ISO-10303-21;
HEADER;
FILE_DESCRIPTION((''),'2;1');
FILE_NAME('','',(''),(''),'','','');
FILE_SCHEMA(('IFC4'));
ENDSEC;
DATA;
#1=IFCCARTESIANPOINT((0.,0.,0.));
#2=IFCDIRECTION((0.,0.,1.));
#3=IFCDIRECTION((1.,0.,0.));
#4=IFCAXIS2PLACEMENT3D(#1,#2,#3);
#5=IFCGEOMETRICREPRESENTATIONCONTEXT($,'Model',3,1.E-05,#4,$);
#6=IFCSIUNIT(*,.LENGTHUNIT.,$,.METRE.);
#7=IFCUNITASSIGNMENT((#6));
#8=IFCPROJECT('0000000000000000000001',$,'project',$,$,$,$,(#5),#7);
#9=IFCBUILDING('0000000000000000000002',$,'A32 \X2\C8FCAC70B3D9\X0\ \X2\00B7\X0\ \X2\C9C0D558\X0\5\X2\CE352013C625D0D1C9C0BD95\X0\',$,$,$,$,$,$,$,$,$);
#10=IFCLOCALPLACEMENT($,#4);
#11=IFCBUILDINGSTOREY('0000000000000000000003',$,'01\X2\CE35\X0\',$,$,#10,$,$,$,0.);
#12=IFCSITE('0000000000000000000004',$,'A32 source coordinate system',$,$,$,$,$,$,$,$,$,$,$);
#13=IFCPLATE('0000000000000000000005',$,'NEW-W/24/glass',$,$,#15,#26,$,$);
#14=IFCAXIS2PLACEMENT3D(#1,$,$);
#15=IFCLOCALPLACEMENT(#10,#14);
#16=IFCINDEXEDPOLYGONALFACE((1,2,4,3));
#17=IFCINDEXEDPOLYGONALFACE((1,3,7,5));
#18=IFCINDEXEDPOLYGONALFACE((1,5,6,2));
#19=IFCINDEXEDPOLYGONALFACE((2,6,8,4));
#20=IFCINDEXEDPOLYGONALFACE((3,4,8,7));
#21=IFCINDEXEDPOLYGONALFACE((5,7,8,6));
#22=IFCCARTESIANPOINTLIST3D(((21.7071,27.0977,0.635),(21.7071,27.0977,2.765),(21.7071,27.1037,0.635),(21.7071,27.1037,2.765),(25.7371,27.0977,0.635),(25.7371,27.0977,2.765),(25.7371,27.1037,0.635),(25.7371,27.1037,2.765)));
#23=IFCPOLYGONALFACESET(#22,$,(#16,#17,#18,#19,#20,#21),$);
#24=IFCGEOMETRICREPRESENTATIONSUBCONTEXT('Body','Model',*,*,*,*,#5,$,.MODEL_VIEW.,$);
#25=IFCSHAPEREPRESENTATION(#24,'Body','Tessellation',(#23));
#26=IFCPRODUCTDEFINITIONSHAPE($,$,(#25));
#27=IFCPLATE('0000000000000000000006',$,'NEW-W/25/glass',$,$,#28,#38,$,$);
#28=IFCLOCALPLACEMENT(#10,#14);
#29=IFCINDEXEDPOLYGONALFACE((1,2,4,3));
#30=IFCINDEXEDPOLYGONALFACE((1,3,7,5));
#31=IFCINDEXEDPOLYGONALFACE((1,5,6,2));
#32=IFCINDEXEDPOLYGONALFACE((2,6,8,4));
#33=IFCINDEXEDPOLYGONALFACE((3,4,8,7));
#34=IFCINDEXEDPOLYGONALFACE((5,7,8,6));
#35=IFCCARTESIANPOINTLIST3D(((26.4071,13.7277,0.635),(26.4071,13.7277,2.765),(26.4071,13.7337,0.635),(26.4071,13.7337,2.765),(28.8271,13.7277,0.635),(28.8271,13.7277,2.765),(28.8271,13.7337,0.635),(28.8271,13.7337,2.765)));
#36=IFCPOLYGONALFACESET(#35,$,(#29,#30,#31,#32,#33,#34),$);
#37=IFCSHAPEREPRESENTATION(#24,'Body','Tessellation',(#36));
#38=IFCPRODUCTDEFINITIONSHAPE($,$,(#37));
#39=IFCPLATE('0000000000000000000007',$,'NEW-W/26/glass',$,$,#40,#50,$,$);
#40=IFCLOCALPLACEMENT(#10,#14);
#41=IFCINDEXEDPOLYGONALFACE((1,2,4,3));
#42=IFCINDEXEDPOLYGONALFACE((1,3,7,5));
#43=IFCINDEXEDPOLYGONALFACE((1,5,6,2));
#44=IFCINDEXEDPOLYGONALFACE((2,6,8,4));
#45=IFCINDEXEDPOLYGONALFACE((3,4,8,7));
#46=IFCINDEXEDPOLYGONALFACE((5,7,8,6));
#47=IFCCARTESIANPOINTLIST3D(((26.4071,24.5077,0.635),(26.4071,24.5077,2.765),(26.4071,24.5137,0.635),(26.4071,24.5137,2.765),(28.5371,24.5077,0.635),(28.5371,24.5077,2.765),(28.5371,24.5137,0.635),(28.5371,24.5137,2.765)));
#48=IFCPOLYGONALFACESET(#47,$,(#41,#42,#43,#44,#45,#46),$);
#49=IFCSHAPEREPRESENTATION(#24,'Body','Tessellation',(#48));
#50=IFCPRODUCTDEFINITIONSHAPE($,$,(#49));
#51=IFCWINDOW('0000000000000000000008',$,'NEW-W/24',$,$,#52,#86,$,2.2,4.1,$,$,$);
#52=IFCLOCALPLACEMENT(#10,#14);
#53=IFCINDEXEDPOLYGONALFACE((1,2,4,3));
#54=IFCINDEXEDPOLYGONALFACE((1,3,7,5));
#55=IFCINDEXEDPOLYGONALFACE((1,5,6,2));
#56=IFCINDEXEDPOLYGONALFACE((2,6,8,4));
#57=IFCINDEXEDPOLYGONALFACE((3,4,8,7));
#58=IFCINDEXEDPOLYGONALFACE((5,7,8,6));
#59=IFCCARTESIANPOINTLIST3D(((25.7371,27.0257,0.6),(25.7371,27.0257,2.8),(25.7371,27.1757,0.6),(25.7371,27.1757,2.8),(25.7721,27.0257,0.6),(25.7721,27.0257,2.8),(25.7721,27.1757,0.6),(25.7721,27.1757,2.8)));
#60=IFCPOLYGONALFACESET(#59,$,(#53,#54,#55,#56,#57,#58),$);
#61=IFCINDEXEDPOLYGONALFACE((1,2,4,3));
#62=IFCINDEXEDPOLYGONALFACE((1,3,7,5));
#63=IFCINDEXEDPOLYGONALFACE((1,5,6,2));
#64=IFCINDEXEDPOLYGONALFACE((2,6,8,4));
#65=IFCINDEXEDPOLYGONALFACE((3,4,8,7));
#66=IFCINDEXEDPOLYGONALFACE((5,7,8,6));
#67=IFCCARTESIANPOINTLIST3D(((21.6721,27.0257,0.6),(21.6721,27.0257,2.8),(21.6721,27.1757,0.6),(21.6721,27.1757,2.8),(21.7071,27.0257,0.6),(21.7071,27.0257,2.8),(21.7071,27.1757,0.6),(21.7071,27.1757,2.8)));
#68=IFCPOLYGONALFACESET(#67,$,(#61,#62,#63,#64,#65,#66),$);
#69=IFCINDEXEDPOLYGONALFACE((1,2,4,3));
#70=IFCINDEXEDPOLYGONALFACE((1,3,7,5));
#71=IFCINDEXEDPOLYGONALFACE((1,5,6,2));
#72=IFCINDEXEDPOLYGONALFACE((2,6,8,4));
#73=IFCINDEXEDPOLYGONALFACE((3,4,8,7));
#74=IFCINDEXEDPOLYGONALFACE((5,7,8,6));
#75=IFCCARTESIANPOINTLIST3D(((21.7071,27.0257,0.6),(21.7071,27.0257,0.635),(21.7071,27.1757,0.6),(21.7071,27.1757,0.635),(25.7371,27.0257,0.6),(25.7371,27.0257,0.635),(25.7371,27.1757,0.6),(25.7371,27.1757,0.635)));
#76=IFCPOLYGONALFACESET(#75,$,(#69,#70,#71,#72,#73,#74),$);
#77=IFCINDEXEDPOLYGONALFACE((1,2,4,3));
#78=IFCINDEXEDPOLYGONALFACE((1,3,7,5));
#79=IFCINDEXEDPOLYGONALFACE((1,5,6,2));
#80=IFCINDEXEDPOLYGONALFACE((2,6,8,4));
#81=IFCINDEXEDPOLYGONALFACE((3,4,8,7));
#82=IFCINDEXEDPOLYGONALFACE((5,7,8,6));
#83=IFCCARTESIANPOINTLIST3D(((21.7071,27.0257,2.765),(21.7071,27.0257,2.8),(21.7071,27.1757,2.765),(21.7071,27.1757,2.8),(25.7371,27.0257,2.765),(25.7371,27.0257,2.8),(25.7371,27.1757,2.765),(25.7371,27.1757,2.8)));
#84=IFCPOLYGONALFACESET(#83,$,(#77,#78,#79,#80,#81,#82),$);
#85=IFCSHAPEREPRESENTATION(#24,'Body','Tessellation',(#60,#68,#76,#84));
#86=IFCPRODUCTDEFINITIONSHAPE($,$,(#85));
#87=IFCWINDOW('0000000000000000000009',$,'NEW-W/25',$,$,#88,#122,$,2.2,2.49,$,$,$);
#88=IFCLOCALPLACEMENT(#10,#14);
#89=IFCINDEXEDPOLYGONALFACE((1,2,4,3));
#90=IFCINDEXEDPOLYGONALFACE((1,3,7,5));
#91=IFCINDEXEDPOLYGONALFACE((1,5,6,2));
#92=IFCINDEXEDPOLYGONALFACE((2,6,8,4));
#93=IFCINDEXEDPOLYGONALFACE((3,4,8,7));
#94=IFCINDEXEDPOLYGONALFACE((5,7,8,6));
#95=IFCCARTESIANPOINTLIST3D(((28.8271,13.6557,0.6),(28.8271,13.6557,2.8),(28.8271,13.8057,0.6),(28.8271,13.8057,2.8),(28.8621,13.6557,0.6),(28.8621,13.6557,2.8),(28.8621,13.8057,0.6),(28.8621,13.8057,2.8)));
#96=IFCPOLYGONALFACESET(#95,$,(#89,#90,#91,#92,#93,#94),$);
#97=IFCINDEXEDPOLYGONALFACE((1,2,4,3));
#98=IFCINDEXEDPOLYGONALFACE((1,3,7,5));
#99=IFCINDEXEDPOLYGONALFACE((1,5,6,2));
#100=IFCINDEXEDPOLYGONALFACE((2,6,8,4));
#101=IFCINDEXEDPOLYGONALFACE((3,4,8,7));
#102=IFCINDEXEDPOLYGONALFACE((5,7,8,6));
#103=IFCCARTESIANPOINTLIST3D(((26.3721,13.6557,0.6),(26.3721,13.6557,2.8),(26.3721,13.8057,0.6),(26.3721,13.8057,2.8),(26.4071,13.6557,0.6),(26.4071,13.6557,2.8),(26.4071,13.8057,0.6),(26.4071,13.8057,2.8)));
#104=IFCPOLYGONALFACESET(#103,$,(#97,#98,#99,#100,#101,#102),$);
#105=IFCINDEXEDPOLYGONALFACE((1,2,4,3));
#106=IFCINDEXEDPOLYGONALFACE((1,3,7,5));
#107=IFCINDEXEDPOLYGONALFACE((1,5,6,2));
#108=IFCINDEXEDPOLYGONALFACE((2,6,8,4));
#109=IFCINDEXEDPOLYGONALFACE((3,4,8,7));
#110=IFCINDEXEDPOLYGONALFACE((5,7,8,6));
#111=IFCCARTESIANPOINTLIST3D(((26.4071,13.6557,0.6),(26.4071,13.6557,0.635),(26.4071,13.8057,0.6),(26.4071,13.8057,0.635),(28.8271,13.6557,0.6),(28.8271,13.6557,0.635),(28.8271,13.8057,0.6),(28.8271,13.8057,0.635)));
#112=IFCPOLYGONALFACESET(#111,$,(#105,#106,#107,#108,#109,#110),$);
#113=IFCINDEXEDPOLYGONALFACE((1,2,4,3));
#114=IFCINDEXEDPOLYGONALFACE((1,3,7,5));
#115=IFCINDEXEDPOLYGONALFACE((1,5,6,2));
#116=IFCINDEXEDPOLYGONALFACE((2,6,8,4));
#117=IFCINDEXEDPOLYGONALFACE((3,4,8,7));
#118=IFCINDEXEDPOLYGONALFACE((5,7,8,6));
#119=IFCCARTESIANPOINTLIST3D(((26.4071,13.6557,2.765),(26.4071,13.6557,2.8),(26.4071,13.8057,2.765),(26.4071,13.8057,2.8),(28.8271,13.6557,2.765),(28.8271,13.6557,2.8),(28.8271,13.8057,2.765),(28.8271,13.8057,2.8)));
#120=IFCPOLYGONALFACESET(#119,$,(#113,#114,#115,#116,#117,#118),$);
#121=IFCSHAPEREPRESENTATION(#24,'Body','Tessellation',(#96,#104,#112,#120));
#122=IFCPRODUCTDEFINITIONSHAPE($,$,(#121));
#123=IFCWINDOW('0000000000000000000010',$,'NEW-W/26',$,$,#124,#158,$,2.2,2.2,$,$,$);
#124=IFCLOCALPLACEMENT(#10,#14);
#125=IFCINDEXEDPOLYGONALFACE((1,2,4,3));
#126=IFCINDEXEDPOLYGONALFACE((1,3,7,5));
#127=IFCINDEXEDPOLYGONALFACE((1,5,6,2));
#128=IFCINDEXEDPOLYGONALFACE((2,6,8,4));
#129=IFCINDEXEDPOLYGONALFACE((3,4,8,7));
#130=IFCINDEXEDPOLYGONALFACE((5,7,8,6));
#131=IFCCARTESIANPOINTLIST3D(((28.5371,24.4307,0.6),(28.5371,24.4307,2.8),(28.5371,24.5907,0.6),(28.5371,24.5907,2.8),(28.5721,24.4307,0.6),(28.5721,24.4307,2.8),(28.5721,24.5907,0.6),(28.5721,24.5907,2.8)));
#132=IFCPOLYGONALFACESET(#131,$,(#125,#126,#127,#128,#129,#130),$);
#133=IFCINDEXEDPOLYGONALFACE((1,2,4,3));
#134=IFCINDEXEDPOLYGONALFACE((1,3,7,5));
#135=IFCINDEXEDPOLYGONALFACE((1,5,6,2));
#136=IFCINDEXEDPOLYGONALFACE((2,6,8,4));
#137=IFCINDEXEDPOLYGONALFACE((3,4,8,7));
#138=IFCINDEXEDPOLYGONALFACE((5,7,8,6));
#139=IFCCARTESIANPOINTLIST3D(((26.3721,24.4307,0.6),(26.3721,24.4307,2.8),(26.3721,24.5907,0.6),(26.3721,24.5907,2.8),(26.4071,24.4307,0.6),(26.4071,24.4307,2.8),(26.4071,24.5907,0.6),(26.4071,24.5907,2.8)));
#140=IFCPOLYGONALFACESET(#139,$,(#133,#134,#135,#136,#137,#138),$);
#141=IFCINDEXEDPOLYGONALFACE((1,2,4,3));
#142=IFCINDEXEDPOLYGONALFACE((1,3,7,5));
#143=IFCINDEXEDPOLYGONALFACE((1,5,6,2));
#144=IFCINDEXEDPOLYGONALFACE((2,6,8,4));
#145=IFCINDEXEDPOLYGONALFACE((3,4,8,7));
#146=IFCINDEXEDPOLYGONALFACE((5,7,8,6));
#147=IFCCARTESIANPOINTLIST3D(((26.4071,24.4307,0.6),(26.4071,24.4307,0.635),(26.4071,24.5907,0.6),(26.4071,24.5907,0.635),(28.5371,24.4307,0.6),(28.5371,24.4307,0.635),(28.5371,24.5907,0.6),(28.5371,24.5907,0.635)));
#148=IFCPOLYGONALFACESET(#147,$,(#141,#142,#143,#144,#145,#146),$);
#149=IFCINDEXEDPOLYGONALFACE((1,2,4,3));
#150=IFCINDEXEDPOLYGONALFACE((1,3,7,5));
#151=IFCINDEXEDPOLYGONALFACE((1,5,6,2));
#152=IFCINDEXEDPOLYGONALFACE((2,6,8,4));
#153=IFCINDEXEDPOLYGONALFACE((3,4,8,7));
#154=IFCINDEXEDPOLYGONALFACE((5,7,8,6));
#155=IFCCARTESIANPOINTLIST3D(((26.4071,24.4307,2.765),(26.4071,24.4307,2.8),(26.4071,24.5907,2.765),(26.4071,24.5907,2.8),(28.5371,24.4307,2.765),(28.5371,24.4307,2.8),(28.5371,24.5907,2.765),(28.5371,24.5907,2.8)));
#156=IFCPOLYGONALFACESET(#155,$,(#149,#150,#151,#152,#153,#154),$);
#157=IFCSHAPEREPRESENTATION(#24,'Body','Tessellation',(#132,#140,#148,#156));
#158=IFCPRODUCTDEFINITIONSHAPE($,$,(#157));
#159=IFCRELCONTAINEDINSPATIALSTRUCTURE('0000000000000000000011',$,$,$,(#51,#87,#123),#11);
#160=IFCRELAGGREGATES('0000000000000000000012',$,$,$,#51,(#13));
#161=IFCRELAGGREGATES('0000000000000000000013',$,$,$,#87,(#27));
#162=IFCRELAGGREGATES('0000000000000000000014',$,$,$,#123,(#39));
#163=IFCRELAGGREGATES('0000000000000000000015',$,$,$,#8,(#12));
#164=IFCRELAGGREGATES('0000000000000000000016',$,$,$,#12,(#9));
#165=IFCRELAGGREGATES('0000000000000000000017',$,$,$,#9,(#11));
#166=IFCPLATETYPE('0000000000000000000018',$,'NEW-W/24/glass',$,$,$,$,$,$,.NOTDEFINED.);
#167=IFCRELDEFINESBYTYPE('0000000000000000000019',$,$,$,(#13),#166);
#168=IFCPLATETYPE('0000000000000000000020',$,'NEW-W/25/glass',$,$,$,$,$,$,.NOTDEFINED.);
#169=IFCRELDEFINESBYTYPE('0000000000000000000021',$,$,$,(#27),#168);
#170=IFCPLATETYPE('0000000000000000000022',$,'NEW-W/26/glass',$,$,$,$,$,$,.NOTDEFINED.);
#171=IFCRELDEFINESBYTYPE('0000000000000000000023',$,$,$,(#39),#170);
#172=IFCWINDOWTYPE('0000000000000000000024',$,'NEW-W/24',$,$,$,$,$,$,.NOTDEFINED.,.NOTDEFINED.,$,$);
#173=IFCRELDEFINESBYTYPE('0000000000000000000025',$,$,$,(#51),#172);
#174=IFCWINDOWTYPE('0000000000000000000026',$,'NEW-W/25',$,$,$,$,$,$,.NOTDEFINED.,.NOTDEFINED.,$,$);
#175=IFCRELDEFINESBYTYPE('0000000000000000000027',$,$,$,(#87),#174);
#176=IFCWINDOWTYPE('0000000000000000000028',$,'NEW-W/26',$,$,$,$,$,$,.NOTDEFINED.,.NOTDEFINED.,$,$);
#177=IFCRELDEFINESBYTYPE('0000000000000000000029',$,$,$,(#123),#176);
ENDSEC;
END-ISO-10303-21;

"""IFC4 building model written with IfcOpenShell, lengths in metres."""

from ifc_helpers import new_model, si_unit, frame, origin, origin_with_axes, place, context, subcontext, project, spatial, polyline, outline, extrude, source, transform, mapped, type_object, type_shapes, element, aggregate, save


model = new_model("IFC4")

# Units and contexts
model_context = context("Model", 3, precision=1e-05, world=origin_with_axes())
body_context = subcontext(model_context, "Body", "Model", "MODEL_VIEW")
ifc_project = project(units=[si_unit("LENGTHUNIT", "METRE")], contexts=[model_context])

# Plates
storey_placement = place(None, origin_with_axes())
plate_type_1 = type_object("IfcPlateType", Name="NEW-W/24/glass", PredefinedType="NOTDEFINED")
shared_shape_1 = source(origin(), body_context, "Body", "SweptSolid", [
    extrude(outline(polyline([(25.7371, 27.0977), (21.7071, 27.0977), (21.7071, 27.1037), (25.7371, 27.1037), (25.7371, 27.0977)])), frame((0.0, 0.0, 0.635)), (0.0, 0.0, 1.0), 2.13),
])
type_shapes(plate_type_1, [shared_shape_1])
window_1_placement = place(storey_placement, origin_with_axes())
plate_1_placement = place(window_1_placement, origin_with_axes())
plate_1 = element("IfcPlate", 1, at=plate_1_placement, type_object=plate_type_1, Name="NEW-W/24/glass", context=body_context, shape_type="MappedRepresentation", body=[
    mapped(shared_shape_1, transform((0.0, 0.0, 0.0), scale=1.0)),
])
plate_type_2 = type_object("IfcPlateType", Name="NEW-W/25/glass", PredefinedType="NOTDEFINED")
shared_shape_2 = source(origin(), body_context, "Body", "SweptSolid", [
    extrude(outline(polyline([(28.8271, 13.7277), (26.4071, 13.7277), (26.4071, 13.7337), (28.8271, 13.7337), (28.8271, 13.7277)])), frame((0.0, 0.0, 0.635)), (0.0, 0.0, 1.0), 2.13),
])
type_shapes(plate_type_2, [shared_shape_2])
window_2_placement = place(storey_placement, origin_with_axes())
plate_2_placement = place(window_2_placement, origin_with_axes())
plate_2 = element("IfcPlate", 2, at=plate_2_placement, type_object=plate_type_2, Name="NEW-W/25/glass", context=body_context, shape_type="MappedRepresentation", body=[
    mapped(shared_shape_2, transform((0.0, 0.0, 0.0), scale=1.0)),
])
plate_type_3 = type_object("IfcPlateType", Name="NEW-W/26/glass", PredefinedType="NOTDEFINED")
shared_shape_3 = source(origin(), body_context, "Body", "SweptSolid", [
    extrude(outline(polyline([(28.5371, 24.5077), (26.4071, 24.5077), (26.4071, 24.5137), (28.5371, 24.5137), (28.5371, 24.5077)])), frame((0.0, 0.0, 0.635)), (0.0, 0.0, 1.0), 2.13),
])
type_shapes(plate_type_3, [shared_shape_3])
window_3_placement = place(storey_placement, origin_with_axes())
plate_3_placement = place(window_3_placement, origin_with_axes())
plate_3 = element("IfcPlate", 3, at=plate_3_placement, type_object=plate_type_3, Name="NEW-W/26/glass", context=body_context, shape_type="MappedRepresentation", body=[
    mapped(shared_shape_3, transform((0.0, 0.0, 0.0), scale=1.0)),
])

# Site, building, storey
site = spatial("IfcSite", under=ifc_project, Name="A32 source coordinate system")
building = spatial("IfcBuilding", under=site, Name="A32 주거동 · 지하5층–옥탑지붕")
storey = spatial("IfcBuildingStorey", under=building, at=storey_placement, Name="01층", Elevation=0.0)

# Windows
window_type_1 = type_object("IfcWindowType", Name="NEW-W/24", PartitioningType="NOTDEFINED", PredefinedType="NOTDEFINED")
shared_shape_4 = source(origin(), body_context, "Body", "SweptSolid", [
    extrude(outline(polyline([(25.7371, 27.0257), (25.7371, 27.1757), (25.7721, 27.1757), (25.7721, 27.0257), (25.7371, 27.0257)])), frame((0.0, 0.0, 0.6)), (0.0, 0.0, 1.0), 2.2),
    extrude(outline(polyline([(21.6721, 27.0257), (21.6721, 27.1757), (21.7071, 27.1757), (21.7071, 27.0257), (21.6721, 27.0257)])), frame((0.0, 0.0, 0.6)), (0.0, 0.0, 1.0), 2.2),
    extrude(outline(polyline([(25.7371, 27.0257), (25.7371, 27.1757), (21.7071, 27.1757), (21.7071, 27.0257), (25.7371, 27.0257)])), frame((0.0, 0.0, 0.6)), (0.0, 0.0, 1.0), 0.035),
    extrude(outline(polyline([(25.7371, 27.0257), (25.7371, 27.1757), (21.7071, 27.1757), (21.7071, 27.0257), (25.7371, 27.0257)])), frame((0.0, 0.0, 2.765)), (0.0, 0.0, 1.0), 0.035),
])
type_shapes(window_type_1, [shared_shape_4])
window_1 = element("IfcWindow", 4, at=window_1_placement, inside=storey, type_object=window_type_1, Name="NEW-W/24", OverallHeight=2.2, OverallWidth=4.1, context=body_context, shape_type="MappedRepresentation", body=[
    mapped(shared_shape_4, transform((0.0, 0.0, 0.0), scale=1.0)),
])
aggregate(window_1, [plate_1])
window_type_2 = type_object("IfcWindowType", Name="NEW-W/25", PartitioningType="NOTDEFINED", PredefinedType="NOTDEFINED")
shared_shape_5 = source(origin(), body_context, "Body", "SweptSolid", [
    extrude(outline(polyline([(28.8271, 13.6557), (28.8271, 13.8057), (28.8621, 13.8057), (28.8621, 13.6557), (28.8271, 13.6557)])), frame((0.0, 0.0, 0.6)), (0.0, 0.0, 1.0), 2.2),
    extrude(outline(polyline([(26.3721, 13.6557), (26.3721, 13.8057), (26.4071, 13.8057), (26.4071, 13.6557), (26.3721, 13.6557)])), frame((0.0, 0.0, 0.6)), (0.0, 0.0, 1.0), 2.2),
    extrude(outline(polyline([(28.8271, 13.6557), (28.8271, 13.8057), (26.4071, 13.8057), (26.4071, 13.6557), (28.8271, 13.6557)])), frame((0.0, 0.0, 0.6)), (0.0, 0.0, 1.0), 0.035),
    extrude(outline(polyline([(28.8271, 13.6557), (28.8271, 13.8057), (26.4071, 13.8057), (26.4071, 13.6557), (28.8271, 13.6557)])), frame((0.0, 0.0, 2.765)), (0.0, 0.0, 1.0), 0.035),
])
type_shapes(window_type_2, [shared_shape_5])
window_2 = element("IfcWindow", 5, at=window_2_placement, inside=storey, type_object=window_type_2, Name="NEW-W/25", OverallHeight=2.2, OverallWidth=2.49, context=body_context, shape_type="MappedRepresentation", body=[
    mapped(shared_shape_5, transform((0.0, 0.0, 0.0), scale=1.0)),
])
aggregate(window_2, [plate_2])
window_type_3 = type_object("IfcWindowType", Name="NEW-W/26", PartitioningType="NOTDEFINED", PredefinedType="NOTDEFINED")
shared_shape_6 = source(origin(), body_context, "Body", "SweptSolid", [
    extrude(outline(polyline([(28.5371, 24.4307), (28.5371, 24.5907), (28.5721, 24.5907), (28.5721, 24.4307), (28.5371, 24.4307)])), frame((0.0, 0.0, 0.6)), (0.0, 0.0, 1.0), 2.2),
    extrude(outline(polyline([(26.3721, 24.4307), (26.3721, 24.5907), (26.4071, 24.5907), (26.4071, 24.4307), (26.3721, 24.4307)])), frame((0.0, 0.0, 0.6)), (0.0, 0.0, 1.0), 2.2),
    extrude(outline(polyline([(28.5371, 24.4307), (28.5371, 24.5907), (26.4071, 24.5907), (26.4071, 24.4307), (28.5371, 24.4307)])), frame((0.0, 0.0, 0.6)), (0.0, 0.0, 1.0), 0.035),
    extrude(outline(polyline([(28.5371, 24.4307), (28.5371, 24.5907), (26.4071, 24.5907), (26.4071, 24.4307), (28.5371, 24.4307)])), frame((0.0, 0.0, 2.765)), (0.0, 0.0, 1.0), 0.035),
])
type_shapes(window_type_3, [shared_shape_6])
window_3 = element("IfcWindow", 6, at=window_3_placement, inside=storey, type_object=window_type_3, Name="NEW-W/26", OverallHeight=2.2, OverallWidth=2.2, context=body_context, shape_type="MappedRepresentation", body=[
    mapped(shared_shape_6, transform((0.0, 0.0, 0.0), scale=1.0)),
])
aggregate(window_3, [plate_3])

save(model, "model.ifc")
